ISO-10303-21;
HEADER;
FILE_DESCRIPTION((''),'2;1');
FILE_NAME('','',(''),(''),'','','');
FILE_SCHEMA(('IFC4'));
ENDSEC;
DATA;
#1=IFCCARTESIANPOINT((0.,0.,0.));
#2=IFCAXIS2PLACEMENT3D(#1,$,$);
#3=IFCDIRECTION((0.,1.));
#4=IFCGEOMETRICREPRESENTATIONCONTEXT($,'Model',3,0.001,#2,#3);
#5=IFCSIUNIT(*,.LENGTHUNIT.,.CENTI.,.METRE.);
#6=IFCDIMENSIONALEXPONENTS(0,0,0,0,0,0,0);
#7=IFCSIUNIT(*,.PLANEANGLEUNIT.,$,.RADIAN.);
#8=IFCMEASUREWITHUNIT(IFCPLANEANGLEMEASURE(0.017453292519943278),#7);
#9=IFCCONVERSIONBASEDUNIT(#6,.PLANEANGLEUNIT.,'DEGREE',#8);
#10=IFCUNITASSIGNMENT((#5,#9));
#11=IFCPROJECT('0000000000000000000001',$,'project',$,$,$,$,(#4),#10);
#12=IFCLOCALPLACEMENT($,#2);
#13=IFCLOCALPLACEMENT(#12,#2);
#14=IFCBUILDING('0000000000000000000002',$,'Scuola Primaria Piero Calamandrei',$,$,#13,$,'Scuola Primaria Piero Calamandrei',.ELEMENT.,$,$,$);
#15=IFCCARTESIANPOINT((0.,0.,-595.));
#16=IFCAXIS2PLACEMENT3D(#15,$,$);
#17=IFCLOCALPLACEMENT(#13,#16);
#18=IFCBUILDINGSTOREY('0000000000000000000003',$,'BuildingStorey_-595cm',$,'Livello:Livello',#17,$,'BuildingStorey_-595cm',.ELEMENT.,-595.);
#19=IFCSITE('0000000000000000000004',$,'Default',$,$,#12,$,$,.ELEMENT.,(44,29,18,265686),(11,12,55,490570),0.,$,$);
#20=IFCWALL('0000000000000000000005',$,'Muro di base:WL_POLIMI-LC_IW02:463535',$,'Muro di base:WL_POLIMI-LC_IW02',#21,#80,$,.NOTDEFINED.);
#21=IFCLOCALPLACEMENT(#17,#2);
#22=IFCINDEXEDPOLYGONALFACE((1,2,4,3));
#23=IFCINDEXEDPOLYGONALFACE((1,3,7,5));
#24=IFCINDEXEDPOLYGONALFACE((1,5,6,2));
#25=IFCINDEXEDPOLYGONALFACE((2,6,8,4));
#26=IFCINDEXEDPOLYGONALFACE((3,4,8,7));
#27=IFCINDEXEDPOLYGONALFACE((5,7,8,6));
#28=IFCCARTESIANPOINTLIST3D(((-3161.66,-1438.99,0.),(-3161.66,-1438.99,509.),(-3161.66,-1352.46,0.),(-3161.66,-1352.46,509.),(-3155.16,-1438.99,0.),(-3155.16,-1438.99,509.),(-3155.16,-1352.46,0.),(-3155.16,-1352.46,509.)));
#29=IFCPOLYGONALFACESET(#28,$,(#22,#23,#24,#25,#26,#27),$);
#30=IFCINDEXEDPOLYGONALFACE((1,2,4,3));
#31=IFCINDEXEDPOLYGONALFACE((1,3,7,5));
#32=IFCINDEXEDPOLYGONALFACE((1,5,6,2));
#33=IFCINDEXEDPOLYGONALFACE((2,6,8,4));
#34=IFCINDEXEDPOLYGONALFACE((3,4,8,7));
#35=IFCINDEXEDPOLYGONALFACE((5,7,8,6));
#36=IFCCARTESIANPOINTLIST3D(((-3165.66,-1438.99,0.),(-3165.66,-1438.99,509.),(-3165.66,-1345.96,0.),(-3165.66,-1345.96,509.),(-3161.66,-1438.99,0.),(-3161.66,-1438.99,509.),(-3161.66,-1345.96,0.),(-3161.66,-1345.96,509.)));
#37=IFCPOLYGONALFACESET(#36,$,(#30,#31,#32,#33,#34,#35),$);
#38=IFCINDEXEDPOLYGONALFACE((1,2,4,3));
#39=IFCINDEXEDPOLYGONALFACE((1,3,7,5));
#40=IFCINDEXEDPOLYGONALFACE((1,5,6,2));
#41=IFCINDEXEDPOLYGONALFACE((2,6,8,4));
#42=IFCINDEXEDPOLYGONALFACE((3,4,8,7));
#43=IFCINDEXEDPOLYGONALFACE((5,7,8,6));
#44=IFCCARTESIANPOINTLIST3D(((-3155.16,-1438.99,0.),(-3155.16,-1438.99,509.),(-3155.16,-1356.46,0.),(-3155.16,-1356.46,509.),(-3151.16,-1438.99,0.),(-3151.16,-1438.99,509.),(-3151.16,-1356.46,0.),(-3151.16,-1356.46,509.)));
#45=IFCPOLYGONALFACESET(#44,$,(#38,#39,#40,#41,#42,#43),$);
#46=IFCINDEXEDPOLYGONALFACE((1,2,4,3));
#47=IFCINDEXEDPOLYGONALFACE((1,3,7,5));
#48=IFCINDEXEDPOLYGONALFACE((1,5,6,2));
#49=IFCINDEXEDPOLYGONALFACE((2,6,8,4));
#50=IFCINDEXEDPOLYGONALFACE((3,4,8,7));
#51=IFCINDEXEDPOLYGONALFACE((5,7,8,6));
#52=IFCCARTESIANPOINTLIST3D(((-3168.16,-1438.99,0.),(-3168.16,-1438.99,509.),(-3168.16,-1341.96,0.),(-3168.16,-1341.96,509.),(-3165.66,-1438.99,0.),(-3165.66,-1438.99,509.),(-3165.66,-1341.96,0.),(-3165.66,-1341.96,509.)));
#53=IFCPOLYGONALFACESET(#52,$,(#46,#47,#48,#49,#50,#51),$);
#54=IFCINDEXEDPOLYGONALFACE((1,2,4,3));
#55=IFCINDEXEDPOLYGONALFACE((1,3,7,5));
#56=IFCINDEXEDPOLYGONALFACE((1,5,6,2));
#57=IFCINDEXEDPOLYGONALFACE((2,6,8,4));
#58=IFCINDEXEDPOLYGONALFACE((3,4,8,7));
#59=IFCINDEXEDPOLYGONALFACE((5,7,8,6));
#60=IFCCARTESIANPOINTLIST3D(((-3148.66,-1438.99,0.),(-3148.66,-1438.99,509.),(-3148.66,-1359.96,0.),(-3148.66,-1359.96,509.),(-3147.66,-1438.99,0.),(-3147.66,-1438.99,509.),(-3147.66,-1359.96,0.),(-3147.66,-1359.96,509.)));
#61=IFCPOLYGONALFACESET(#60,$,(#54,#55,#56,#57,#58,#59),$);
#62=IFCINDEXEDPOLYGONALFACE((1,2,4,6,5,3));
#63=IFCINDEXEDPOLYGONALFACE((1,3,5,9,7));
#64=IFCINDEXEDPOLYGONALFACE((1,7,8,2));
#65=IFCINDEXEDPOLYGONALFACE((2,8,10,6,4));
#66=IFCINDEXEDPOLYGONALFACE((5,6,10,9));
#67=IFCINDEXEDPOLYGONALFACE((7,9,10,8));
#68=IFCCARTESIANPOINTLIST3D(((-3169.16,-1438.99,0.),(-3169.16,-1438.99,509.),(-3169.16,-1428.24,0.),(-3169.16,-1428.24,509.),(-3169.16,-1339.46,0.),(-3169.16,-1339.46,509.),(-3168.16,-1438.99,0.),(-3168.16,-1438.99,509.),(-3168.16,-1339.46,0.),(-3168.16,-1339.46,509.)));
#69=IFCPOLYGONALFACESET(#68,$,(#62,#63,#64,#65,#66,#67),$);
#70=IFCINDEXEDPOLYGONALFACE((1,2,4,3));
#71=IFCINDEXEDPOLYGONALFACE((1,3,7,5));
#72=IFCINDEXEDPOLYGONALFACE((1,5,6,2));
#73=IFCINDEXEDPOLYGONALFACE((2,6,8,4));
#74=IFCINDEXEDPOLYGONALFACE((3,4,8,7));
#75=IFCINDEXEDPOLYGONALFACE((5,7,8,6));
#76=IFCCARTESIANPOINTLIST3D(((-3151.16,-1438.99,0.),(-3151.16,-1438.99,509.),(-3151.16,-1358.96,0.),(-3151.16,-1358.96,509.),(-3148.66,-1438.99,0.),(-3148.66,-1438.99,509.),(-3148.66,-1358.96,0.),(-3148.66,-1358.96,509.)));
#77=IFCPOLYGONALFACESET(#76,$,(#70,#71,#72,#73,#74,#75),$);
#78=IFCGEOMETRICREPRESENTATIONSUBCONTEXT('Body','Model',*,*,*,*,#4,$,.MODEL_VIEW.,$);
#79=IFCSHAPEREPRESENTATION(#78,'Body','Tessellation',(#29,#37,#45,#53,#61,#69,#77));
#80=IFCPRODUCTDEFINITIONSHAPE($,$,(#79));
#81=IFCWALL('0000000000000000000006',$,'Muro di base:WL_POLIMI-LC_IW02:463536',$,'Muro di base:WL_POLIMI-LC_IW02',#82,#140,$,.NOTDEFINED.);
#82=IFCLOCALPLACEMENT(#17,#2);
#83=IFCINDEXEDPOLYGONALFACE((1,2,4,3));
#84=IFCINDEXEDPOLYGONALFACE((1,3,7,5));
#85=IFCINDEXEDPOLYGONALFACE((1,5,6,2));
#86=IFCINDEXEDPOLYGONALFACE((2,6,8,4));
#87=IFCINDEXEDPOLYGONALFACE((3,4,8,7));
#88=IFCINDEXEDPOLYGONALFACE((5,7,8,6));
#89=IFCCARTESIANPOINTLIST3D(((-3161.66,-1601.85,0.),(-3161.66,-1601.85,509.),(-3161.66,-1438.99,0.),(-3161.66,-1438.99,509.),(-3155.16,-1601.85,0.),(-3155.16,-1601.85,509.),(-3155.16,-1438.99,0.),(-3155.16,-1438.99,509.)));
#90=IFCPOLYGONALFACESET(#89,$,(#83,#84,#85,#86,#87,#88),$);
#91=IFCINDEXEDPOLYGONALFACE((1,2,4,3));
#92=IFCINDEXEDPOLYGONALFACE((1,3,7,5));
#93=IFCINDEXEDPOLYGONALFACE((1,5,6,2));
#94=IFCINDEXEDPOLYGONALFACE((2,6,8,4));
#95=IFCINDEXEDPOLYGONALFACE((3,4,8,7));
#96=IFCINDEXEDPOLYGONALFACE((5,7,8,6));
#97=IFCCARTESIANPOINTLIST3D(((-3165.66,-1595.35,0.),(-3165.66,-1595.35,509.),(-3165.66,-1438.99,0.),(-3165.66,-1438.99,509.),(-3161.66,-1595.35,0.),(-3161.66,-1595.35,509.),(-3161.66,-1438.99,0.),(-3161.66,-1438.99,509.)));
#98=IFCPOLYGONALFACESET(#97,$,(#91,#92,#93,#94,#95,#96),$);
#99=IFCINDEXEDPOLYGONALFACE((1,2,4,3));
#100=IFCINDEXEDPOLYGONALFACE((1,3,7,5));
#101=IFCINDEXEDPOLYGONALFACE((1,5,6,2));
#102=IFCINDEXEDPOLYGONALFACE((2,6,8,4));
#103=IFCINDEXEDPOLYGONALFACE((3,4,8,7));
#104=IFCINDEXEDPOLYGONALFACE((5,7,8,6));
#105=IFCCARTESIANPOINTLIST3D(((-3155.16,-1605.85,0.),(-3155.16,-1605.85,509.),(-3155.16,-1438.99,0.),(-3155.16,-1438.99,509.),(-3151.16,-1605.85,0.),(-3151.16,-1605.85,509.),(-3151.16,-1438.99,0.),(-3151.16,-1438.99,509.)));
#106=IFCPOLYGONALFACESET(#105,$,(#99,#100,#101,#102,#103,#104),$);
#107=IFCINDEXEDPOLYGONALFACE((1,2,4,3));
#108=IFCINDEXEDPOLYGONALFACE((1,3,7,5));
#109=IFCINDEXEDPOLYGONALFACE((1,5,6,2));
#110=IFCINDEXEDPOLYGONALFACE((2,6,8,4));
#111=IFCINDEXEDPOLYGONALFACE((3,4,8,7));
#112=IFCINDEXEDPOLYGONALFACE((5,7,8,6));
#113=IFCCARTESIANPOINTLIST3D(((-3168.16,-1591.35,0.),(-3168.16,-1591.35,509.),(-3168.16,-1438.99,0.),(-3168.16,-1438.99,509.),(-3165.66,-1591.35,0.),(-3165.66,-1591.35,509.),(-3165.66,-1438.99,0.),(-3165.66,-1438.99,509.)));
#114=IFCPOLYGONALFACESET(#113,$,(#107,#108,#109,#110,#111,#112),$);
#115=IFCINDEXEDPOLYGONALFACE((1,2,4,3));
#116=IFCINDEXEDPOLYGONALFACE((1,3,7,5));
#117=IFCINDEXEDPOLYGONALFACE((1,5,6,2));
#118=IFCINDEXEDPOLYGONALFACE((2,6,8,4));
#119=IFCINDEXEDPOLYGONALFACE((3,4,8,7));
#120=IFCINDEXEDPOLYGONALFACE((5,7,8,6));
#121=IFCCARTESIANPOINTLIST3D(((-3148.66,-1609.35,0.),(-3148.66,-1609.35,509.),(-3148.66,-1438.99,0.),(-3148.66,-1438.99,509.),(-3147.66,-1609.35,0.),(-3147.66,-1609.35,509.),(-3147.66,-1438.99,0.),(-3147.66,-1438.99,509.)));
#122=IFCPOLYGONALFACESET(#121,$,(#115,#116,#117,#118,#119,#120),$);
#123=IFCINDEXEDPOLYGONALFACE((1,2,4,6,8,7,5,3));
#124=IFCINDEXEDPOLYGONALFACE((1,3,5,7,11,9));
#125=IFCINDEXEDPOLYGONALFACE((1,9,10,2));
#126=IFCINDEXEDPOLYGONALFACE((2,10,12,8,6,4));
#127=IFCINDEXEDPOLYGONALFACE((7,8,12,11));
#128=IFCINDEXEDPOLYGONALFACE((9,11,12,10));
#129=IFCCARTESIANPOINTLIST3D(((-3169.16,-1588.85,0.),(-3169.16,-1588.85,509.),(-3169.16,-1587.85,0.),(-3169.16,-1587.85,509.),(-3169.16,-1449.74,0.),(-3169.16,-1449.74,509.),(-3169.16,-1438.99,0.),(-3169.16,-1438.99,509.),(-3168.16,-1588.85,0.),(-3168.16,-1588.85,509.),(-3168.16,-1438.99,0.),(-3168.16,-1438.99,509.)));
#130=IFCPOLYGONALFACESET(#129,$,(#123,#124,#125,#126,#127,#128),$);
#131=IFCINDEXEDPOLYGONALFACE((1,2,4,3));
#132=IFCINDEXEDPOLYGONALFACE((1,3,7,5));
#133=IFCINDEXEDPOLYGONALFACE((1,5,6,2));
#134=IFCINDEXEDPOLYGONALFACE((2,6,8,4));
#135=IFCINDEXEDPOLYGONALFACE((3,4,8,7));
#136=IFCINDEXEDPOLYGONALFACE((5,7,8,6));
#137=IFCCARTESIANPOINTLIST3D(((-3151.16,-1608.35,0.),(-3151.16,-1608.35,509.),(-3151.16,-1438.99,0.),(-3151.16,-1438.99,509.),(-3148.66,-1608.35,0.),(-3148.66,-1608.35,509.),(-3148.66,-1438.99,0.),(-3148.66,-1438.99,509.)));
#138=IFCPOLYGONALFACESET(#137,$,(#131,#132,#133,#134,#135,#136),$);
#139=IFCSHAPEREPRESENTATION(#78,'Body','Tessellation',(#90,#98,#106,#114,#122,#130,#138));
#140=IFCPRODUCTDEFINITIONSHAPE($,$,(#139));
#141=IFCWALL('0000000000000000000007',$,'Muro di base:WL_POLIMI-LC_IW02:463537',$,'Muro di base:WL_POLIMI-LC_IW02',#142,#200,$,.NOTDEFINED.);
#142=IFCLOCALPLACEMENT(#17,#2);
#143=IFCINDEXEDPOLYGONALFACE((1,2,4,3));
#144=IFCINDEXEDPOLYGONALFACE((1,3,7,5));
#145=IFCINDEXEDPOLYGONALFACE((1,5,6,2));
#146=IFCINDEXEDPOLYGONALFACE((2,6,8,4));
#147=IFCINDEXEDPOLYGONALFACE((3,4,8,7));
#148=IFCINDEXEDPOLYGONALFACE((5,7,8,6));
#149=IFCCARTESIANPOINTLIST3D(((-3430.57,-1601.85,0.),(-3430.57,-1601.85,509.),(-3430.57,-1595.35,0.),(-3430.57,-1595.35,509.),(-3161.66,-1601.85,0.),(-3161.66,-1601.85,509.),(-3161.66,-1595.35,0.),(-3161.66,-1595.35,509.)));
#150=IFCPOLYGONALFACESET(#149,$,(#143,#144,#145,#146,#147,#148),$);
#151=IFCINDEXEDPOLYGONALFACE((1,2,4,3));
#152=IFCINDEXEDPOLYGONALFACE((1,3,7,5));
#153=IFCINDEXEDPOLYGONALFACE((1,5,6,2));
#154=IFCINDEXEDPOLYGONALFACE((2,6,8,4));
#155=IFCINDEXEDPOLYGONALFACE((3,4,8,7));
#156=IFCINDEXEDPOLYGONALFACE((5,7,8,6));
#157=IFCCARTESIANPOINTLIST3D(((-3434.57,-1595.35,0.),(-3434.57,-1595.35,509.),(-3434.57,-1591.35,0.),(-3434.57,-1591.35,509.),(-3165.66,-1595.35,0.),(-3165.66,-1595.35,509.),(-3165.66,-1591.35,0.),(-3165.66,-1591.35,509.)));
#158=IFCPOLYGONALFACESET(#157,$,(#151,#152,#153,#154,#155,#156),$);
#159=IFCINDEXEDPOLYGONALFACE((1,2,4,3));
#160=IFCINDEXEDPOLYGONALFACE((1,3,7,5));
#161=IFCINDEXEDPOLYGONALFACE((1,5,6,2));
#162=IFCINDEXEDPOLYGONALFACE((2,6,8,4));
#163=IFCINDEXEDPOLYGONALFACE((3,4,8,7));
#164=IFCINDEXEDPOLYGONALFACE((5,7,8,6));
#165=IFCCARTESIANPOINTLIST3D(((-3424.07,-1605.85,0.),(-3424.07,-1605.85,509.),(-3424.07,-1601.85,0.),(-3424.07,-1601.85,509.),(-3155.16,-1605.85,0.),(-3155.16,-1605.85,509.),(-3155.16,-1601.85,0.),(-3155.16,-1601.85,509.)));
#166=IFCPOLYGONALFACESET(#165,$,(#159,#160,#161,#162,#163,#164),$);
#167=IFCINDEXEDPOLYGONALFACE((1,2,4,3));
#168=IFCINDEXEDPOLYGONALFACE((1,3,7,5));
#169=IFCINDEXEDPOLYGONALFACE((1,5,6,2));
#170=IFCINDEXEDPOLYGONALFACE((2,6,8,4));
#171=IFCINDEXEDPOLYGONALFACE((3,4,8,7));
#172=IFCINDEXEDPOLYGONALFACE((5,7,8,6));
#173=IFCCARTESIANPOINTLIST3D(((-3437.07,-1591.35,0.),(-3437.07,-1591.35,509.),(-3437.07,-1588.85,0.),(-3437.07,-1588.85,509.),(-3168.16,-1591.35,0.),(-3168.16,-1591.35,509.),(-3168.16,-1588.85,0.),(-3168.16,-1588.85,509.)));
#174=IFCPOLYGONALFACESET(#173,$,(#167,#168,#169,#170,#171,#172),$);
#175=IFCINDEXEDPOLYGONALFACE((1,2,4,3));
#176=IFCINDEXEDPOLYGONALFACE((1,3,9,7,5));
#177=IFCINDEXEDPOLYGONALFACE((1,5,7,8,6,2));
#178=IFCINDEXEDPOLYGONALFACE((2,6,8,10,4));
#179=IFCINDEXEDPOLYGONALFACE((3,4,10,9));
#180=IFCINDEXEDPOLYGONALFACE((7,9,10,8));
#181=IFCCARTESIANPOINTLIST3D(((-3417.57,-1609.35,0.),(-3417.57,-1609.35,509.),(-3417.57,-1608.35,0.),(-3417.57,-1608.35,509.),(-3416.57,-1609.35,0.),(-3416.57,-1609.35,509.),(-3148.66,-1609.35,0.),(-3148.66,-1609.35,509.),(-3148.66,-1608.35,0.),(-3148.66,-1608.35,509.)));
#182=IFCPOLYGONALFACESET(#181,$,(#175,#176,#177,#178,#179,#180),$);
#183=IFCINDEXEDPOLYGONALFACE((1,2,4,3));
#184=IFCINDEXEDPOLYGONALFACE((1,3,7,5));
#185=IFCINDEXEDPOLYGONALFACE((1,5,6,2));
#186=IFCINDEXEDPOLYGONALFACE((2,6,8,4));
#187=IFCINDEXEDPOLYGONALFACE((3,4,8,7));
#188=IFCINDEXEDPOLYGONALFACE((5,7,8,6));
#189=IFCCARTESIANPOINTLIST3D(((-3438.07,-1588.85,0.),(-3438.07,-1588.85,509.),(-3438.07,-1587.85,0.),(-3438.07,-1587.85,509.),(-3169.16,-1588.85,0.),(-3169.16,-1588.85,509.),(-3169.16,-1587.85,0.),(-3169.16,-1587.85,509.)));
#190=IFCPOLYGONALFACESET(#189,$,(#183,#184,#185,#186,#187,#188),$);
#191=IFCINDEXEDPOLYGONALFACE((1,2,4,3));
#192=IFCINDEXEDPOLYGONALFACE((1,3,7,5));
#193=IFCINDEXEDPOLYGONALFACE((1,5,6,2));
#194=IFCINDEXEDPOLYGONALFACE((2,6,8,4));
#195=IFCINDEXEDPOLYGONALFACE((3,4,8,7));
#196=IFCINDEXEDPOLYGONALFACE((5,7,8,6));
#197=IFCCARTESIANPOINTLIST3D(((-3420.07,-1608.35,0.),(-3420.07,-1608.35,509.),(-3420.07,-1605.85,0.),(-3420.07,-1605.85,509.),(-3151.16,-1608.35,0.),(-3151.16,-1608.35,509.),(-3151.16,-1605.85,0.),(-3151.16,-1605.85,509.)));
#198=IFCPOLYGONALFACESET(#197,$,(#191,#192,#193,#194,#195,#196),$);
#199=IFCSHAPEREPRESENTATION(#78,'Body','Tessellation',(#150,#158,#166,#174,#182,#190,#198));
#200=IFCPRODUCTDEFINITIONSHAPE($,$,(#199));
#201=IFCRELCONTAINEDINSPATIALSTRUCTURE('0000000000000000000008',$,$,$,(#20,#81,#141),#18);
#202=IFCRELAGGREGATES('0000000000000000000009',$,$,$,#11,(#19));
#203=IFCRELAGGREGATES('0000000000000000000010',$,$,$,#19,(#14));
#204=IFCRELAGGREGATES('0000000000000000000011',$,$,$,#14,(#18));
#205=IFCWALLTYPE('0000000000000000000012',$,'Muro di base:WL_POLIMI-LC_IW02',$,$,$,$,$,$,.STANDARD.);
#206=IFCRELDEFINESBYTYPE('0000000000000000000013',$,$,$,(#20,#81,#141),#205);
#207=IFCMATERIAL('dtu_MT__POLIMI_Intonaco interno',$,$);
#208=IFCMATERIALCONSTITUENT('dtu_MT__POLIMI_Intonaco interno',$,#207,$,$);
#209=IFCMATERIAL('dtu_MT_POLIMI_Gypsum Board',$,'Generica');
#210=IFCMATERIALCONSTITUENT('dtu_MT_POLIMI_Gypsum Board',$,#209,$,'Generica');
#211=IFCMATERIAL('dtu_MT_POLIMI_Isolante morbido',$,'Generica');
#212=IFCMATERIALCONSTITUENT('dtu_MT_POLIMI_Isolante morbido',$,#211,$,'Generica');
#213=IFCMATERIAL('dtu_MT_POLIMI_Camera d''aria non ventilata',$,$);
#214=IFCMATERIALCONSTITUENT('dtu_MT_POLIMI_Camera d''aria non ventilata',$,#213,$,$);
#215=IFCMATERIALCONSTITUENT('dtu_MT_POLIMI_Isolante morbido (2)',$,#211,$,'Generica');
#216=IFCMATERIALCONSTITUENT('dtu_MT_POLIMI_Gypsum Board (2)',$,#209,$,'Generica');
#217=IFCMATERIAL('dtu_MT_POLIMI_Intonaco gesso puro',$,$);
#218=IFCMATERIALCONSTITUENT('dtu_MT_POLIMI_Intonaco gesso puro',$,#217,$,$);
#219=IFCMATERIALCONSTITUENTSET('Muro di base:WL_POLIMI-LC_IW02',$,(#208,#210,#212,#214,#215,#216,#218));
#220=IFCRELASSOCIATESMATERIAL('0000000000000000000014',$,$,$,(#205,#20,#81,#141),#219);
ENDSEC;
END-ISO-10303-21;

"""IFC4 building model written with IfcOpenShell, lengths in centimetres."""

from ifc_helpers import new_model, entity, si_unit, converted_unit, direction, frame, origin, place, context, subcontext, project, spatial, indexed_curve, outline, extrude, material, constituent, constituent_set, type_object, element, save


model = new_model("IFC4")

# Units and contexts
model_context = context("Model", 3, precision=0.001, world=origin(), true_north=direction((0.0, 1.0)))
body_context = subcontext(model_context, "Body", "Model", "MODEL_VIEW")
ifc_project = project(units=[si_unit("LENGTHUNIT", "METRE", prefix="CENTI"), converted_unit("PLANEANGLEUNIT", "DEGREE", entity("IfcPlaneAngleMeasure", 0.017453292519943278), si_unit("PLANEANGLEUNIT", "RADIAN"), dimensions=[0, 0, 0, 0, 0, 0, 0])], contexts=[model_context])

# Site, building, storey
site_placement = place(None, origin())
site = spatial("IfcSite", under=ifc_project, at=site_placement, Name="Default", CompositionType="ELEMENT", RefLatitude=(44, 29, 18, 265686), RefLongitude=(11, 12, 55, 490570), RefElevation=0.0)
building_placement = place(site_placement, origin())
building = spatial("IfcBuilding", under=site, at=building_placement, Name="Scuola Primaria Piero Calamandrei", LongName="Scuola Primaria Piero Calamandrei", CompositionType="ELEMENT")
storey_placement = place(building_placement, frame((0.0, 0.0, -595.0)))
storey = spatial("IfcBuildingStorey", under=building, at=storey_placement, Name="BuildingStorey_-595cm", ObjectType="Livello:Livello", LongName="BuildingStorey_-595cm", CompositionType="ELEMENT", Elevation=-595.0)

# Shared definitions
ifc_material_1 = material(Name="dtu_MT__POLIMI_Intonaco interno")

# Shared definitions
ifc_constituent_1 = constituent(ifc_material_1, Name="dtu_MT__POLIMI_Intonaco interno")
ifc_material_2 = material(Name="dtu_MT_POLIMI_Gypsum Board", Category="Generica")
ifc_constituent_2 = constituent(ifc_material_2, Name="dtu_MT_POLIMI_Gypsum Board", Category="Generica")
ifc_material_3 = material(Name="dtu_MT_POLIMI_Isolante morbido", Category="Generica")
ifc_constituent_3 = constituent(ifc_material_3, Name="dtu_MT_POLIMI_Isolante morbido", Category="Generica")
ifc_material_4 = material(Name="dtu_MT_POLIMI_Camera d'aria non ventilata")
ifc_constituent_4 = constituent(ifc_material_4, Name="dtu_MT_POLIMI_Camera d'aria non ventilata")
ifc_constituent_5 = constituent(ifc_material_3, Name="dtu_MT_POLIMI_Isolante morbido (2)", Category="Generica")
ifc_constituent_6 = constituent(ifc_material_2, Name="dtu_MT_POLIMI_Gypsum Board (2)", Category="Generica")
ifc_material_5 = material(Name="dtu_MT_POLIMI_Intonaco gesso puro")
ifc_constituent_7 = constituent(ifc_material_5, Name="dtu_MT_POLIMI_Intonaco gesso puro")
ifc_constituent_set_1 = constituent_set(constituents=[ifc_constituent_1, ifc_constituent_2, ifc_constituent_3, ifc_constituent_4, ifc_constituent_5, ifc_constituent_6, ifc_constituent_7], Name="Muro di base:WL_POLIMI-LC_IW02")
wall_type_1 = type_object("IfcWallType", Name="Muro di base:WL_POLIMI-LC_IW02", PredefinedType="STANDARD", material=ifc_constituent_set_1)

# Walls
wall_1_placement = place(storey_placement, frame((-3158.41, -1438.99, 0.0), z_axis=(0.0, 0.0, 1.0), x_axis=(0.0, 1.0, 0.0)))
element("IfcWall", 1, at=wall_1_placement, inside=storey, type_object=wall_type_1, material=ifc_constituent_set_1, Name="Muro di base:WL_POLIMI-LC_IW02:463535", ObjectType="Muro di base:WL_POLIMI-LC_IW02", PredefinedType="NOTDEFINED", context=body_context, shape_type="SweptSolid", body=[
    extrude(outline(indexed_curve([(-43.27, -3.25), (43.27, -3.25), (43.27, 3.25), (-43.27, 3.25), (-43.27, -3.25)], self_intersect=False)), frame((43.27, 0.0, 0.0)), (0.0, 0.0, 1.0), 509.0),
    extrude(outline(indexed_curve([(-46.52, -2.0), (46.52, -2.0), (46.52, 2.0), (-46.52, 2.0), (-46.52, -2.0)], self_intersect=False)), frame((46.52, 5.25, 0.0)), (0.0, 0.0, 1.0), 509.0),
    extrude(outline(indexed_curve([(-41.27, -2.0), (41.27, -2.0), (41.27, 2.0), (-41.27, 2.0), (-41.27, -2.0)], self_intersect=False)), frame((41.27, -5.25, 0.0)), (0.0, 0.0, 1.0), 509.0),
    extrude(outline(indexed_curve([(-48.52, -1.25), (48.52, -1.25), (48.52, 1.25), (-48.52, 1.25), (-48.52, -1.25)], self_intersect=False)), frame((48.52, 8.5, 0.0)), (0.0, 0.0, 1.0), 509.0),
    extrude(outline(indexed_curve([(-0.5, -39.52), (0.5, -39.52), (0.5, 39.52), (-0.5, 39.52), (-0.5, -39.52)], self_intersect=False)), frame((39.52, -10.25, 0.0), z_axis=(0.0, 0.0, 1.0), x_axis=(0.0, 1.0, 0.0)), (0.0, 0.0, 1.0), 509.0),
    extrude(outline(indexed_curve([(31.21, -0.4), (41.96, -0.4), (41.96, 0.6), (-57.57, 0.6), (-57.57, -0.4), (31.21, -0.4)], self_intersect=False)), frame((41.96, 10.35, 0.0), z_axis=(0.0, 0.0, 1.0), x_axis=(-1.0, 0.0, 0.0)), (0.0, 0.0, 1.0), 509.0),
    extrude(outline(indexed_curve([(-40.02, -1.25), (40.02, -1.25), (40.02, 1.25), (-40.02, 1.25), (-40.02, -1.25)], self_intersect=False)), frame((40.02, -8.5, 0.0)), (0.0, 0.0, 1.0), 509.0),
])
wall_2_placement = place(storey_placement, frame((-3158.41, -1609.35, 0.0), z_axis=(0.0, 0.0, 1.0), x_axis=(0.0, 1.0, 0.0)))
element("IfcWall", 2, at=wall_2_placement, inside=storey, type_object=wall_type_1, material=ifc_constituent_set_1, Name="Muro di base:WL_POLIMI-LC_IW02:463536", ObjectType="Muro di base:WL_POLIMI-LC_IW02", PredefinedType="NOTDEFINED", context=body_context, shape_type="SweptSolid", body=[
    extrude(outline(indexed_curve([(-81.43, -3.25), (81.43, -3.25), (81.43, 3.25), (-81.43, 3.25), (-81.43, -3.25)], self_intersect=False)), frame((88.93, 0.0, 0.0)), (0.0, 0.0, 1.0), 509.0),
    extrude(outline(indexed_curve([(-78.18, -2.0), (78.18, -2.0), (78.18, 2.0), (-78.18, 2.0), (-78.18, -2.0)], self_intersect=False)), frame((92.18, 5.25, 0.0)), (0.0, 0.0, 1.0), 509.0),
    extrude(outline(indexed_curve([(-83.43, -2.0), (83.43, -2.0), (83.43, 2.0), (-83.43, 2.0), (-83.43, -2.0)], self_intersect=False)), frame((86.93, -5.25, 0.0)), (0.0, 0.0, 1.0), 509.0),
    extrude(outline(indexed_curve([(-76.18, -1.25), (76.18, -1.25), (76.18, 1.25), (-76.18, 1.25), (-76.18, -1.25)], self_intersect=False)), frame((94.18, 8.5, 0.0)), (0.0, 0.0, 1.0), 509.0),
    extrude(outline(indexed_curve([(-0.5, -85.18), (0.5, -85.18), (0.5, 85.18), (-0.5, 85.18), (-0.5, -85.18)], self_intersect=False)), frame((85.18, -10.25, 0.0), z_axis=(0.0, 0.0, 1.0), x_axis=(0.0, 1.0, 0.0)), (0.0, 0.0, 1.0), 509.0),
    extrude(outline(indexed_curve([(-65.8, -0.33), (72.3, -0.33), (73.3, -0.33), (73.3, 0.67), (-76.55, 0.67), (-76.55, -0.33), (-65.8, -0.33)], self_intersect=False)), frame((93.8, 10.42, 0.0), z_axis=(0.0, 0.0, 1.0), x_axis=(-1.0, 0.0, 0.0)), (0.0, 0.0, 1.0), 509.0),
    extrude(outline(indexed_curve([(-84.68, -1.25), (84.68, -1.25), (84.68, 1.25), (-84.68, 1.25), (-84.68, -1.25)], self_intersect=False)), frame((85.68, -8.5, 0.0)), (0.0, 0.0, 1.0), 509.0),
])
wall_3_placement = place(storey_placement, frame((-3438.07, -1598.6, 0.0)))
element("IfcWall", 3, at=wall_3_placement, inside=storey, type_object=wall_type_1, material=ifc_constituent_set_1, Name="Muro di base:WL_POLIMI-LC_IW02:463537", ObjectType="Muro di base:WL_POLIMI-LC_IW02", PredefinedType="NOTDEFINED", context=body_context, shape_type="SweptSolid", body=[
    extrude(outline(indexed_curve([(-134.45, -3.25), (134.45, -3.25), (134.45, 3.25), (-134.45, 3.25), (-134.45, -3.25)], self_intersect=False)), frame((141.95, 0.0, 0.0)), (0.0, 0.0, 1.0), 509.0),
    extrude(outline(indexed_curve([(-134.45, -2.0), (134.45, -2.0), (134.45, 2.0), (-134.45, 2.0), (-134.45, -2.0)], self_intersect=False)), frame((137.95, 5.25, 0.0)), (0.0, 0.0, 1.0), 509.0),
    extrude(outline(indexed_curve([(-134.45, -2.0), (134.45, -2.0), (134.45, 2.0), (-134.45, 2.0), (-134.45, -2.0)], self_intersect=False)), frame((148.45, -5.25, 0.0)), (0.0, 0.0, 1.0), 509.0),
    extrude(outline(indexed_curve([(-134.45, -1.25), (134.45, -1.25), (134.45, 1.25), (-134.45, 1.25), (-134.45, -1.25)], self_intersect=False)), frame((135.45, 8.5, 0.0)), (0.0, 0.0, 1.0), 509.0),
    extrude(outline(indexed_curve([(-106.76, -0.4), (161.15, -0.4), (161.15, 0.6), (-107.76, 0.6), (-107.76, -0.4), (-106.76, -0.4)], self_intersect=False)), frame((128.26, -10.35, 0.0)), (0.0, 0.0, 1.0), 509.0),
    extrude(outline(indexed_curve([(-0.5, -134.45), (0.5, -134.45), (0.5, 134.45), (-0.5, 134.45), (-0.5, -134.45)], self_intersect=False)), frame((134.45, 10.25, 0.0), z_axis=(0.0, 0.0, 1.0), x_axis=(0.0, -1.0, 0.0)), (0.0, 0.0, 1.0), 509.0),
    extrude(outline(indexed_curve([(-134.45, -1.25), (134.45, -1.25), (134.45, 1.25), (-134.45, 1.25), (-134.45, -1.25)], self_intersect=False)), frame((152.45, -8.5, 0.0)), (0.0, 0.0, 1.0), 509.0),
])

save(model, "model.ifc")
